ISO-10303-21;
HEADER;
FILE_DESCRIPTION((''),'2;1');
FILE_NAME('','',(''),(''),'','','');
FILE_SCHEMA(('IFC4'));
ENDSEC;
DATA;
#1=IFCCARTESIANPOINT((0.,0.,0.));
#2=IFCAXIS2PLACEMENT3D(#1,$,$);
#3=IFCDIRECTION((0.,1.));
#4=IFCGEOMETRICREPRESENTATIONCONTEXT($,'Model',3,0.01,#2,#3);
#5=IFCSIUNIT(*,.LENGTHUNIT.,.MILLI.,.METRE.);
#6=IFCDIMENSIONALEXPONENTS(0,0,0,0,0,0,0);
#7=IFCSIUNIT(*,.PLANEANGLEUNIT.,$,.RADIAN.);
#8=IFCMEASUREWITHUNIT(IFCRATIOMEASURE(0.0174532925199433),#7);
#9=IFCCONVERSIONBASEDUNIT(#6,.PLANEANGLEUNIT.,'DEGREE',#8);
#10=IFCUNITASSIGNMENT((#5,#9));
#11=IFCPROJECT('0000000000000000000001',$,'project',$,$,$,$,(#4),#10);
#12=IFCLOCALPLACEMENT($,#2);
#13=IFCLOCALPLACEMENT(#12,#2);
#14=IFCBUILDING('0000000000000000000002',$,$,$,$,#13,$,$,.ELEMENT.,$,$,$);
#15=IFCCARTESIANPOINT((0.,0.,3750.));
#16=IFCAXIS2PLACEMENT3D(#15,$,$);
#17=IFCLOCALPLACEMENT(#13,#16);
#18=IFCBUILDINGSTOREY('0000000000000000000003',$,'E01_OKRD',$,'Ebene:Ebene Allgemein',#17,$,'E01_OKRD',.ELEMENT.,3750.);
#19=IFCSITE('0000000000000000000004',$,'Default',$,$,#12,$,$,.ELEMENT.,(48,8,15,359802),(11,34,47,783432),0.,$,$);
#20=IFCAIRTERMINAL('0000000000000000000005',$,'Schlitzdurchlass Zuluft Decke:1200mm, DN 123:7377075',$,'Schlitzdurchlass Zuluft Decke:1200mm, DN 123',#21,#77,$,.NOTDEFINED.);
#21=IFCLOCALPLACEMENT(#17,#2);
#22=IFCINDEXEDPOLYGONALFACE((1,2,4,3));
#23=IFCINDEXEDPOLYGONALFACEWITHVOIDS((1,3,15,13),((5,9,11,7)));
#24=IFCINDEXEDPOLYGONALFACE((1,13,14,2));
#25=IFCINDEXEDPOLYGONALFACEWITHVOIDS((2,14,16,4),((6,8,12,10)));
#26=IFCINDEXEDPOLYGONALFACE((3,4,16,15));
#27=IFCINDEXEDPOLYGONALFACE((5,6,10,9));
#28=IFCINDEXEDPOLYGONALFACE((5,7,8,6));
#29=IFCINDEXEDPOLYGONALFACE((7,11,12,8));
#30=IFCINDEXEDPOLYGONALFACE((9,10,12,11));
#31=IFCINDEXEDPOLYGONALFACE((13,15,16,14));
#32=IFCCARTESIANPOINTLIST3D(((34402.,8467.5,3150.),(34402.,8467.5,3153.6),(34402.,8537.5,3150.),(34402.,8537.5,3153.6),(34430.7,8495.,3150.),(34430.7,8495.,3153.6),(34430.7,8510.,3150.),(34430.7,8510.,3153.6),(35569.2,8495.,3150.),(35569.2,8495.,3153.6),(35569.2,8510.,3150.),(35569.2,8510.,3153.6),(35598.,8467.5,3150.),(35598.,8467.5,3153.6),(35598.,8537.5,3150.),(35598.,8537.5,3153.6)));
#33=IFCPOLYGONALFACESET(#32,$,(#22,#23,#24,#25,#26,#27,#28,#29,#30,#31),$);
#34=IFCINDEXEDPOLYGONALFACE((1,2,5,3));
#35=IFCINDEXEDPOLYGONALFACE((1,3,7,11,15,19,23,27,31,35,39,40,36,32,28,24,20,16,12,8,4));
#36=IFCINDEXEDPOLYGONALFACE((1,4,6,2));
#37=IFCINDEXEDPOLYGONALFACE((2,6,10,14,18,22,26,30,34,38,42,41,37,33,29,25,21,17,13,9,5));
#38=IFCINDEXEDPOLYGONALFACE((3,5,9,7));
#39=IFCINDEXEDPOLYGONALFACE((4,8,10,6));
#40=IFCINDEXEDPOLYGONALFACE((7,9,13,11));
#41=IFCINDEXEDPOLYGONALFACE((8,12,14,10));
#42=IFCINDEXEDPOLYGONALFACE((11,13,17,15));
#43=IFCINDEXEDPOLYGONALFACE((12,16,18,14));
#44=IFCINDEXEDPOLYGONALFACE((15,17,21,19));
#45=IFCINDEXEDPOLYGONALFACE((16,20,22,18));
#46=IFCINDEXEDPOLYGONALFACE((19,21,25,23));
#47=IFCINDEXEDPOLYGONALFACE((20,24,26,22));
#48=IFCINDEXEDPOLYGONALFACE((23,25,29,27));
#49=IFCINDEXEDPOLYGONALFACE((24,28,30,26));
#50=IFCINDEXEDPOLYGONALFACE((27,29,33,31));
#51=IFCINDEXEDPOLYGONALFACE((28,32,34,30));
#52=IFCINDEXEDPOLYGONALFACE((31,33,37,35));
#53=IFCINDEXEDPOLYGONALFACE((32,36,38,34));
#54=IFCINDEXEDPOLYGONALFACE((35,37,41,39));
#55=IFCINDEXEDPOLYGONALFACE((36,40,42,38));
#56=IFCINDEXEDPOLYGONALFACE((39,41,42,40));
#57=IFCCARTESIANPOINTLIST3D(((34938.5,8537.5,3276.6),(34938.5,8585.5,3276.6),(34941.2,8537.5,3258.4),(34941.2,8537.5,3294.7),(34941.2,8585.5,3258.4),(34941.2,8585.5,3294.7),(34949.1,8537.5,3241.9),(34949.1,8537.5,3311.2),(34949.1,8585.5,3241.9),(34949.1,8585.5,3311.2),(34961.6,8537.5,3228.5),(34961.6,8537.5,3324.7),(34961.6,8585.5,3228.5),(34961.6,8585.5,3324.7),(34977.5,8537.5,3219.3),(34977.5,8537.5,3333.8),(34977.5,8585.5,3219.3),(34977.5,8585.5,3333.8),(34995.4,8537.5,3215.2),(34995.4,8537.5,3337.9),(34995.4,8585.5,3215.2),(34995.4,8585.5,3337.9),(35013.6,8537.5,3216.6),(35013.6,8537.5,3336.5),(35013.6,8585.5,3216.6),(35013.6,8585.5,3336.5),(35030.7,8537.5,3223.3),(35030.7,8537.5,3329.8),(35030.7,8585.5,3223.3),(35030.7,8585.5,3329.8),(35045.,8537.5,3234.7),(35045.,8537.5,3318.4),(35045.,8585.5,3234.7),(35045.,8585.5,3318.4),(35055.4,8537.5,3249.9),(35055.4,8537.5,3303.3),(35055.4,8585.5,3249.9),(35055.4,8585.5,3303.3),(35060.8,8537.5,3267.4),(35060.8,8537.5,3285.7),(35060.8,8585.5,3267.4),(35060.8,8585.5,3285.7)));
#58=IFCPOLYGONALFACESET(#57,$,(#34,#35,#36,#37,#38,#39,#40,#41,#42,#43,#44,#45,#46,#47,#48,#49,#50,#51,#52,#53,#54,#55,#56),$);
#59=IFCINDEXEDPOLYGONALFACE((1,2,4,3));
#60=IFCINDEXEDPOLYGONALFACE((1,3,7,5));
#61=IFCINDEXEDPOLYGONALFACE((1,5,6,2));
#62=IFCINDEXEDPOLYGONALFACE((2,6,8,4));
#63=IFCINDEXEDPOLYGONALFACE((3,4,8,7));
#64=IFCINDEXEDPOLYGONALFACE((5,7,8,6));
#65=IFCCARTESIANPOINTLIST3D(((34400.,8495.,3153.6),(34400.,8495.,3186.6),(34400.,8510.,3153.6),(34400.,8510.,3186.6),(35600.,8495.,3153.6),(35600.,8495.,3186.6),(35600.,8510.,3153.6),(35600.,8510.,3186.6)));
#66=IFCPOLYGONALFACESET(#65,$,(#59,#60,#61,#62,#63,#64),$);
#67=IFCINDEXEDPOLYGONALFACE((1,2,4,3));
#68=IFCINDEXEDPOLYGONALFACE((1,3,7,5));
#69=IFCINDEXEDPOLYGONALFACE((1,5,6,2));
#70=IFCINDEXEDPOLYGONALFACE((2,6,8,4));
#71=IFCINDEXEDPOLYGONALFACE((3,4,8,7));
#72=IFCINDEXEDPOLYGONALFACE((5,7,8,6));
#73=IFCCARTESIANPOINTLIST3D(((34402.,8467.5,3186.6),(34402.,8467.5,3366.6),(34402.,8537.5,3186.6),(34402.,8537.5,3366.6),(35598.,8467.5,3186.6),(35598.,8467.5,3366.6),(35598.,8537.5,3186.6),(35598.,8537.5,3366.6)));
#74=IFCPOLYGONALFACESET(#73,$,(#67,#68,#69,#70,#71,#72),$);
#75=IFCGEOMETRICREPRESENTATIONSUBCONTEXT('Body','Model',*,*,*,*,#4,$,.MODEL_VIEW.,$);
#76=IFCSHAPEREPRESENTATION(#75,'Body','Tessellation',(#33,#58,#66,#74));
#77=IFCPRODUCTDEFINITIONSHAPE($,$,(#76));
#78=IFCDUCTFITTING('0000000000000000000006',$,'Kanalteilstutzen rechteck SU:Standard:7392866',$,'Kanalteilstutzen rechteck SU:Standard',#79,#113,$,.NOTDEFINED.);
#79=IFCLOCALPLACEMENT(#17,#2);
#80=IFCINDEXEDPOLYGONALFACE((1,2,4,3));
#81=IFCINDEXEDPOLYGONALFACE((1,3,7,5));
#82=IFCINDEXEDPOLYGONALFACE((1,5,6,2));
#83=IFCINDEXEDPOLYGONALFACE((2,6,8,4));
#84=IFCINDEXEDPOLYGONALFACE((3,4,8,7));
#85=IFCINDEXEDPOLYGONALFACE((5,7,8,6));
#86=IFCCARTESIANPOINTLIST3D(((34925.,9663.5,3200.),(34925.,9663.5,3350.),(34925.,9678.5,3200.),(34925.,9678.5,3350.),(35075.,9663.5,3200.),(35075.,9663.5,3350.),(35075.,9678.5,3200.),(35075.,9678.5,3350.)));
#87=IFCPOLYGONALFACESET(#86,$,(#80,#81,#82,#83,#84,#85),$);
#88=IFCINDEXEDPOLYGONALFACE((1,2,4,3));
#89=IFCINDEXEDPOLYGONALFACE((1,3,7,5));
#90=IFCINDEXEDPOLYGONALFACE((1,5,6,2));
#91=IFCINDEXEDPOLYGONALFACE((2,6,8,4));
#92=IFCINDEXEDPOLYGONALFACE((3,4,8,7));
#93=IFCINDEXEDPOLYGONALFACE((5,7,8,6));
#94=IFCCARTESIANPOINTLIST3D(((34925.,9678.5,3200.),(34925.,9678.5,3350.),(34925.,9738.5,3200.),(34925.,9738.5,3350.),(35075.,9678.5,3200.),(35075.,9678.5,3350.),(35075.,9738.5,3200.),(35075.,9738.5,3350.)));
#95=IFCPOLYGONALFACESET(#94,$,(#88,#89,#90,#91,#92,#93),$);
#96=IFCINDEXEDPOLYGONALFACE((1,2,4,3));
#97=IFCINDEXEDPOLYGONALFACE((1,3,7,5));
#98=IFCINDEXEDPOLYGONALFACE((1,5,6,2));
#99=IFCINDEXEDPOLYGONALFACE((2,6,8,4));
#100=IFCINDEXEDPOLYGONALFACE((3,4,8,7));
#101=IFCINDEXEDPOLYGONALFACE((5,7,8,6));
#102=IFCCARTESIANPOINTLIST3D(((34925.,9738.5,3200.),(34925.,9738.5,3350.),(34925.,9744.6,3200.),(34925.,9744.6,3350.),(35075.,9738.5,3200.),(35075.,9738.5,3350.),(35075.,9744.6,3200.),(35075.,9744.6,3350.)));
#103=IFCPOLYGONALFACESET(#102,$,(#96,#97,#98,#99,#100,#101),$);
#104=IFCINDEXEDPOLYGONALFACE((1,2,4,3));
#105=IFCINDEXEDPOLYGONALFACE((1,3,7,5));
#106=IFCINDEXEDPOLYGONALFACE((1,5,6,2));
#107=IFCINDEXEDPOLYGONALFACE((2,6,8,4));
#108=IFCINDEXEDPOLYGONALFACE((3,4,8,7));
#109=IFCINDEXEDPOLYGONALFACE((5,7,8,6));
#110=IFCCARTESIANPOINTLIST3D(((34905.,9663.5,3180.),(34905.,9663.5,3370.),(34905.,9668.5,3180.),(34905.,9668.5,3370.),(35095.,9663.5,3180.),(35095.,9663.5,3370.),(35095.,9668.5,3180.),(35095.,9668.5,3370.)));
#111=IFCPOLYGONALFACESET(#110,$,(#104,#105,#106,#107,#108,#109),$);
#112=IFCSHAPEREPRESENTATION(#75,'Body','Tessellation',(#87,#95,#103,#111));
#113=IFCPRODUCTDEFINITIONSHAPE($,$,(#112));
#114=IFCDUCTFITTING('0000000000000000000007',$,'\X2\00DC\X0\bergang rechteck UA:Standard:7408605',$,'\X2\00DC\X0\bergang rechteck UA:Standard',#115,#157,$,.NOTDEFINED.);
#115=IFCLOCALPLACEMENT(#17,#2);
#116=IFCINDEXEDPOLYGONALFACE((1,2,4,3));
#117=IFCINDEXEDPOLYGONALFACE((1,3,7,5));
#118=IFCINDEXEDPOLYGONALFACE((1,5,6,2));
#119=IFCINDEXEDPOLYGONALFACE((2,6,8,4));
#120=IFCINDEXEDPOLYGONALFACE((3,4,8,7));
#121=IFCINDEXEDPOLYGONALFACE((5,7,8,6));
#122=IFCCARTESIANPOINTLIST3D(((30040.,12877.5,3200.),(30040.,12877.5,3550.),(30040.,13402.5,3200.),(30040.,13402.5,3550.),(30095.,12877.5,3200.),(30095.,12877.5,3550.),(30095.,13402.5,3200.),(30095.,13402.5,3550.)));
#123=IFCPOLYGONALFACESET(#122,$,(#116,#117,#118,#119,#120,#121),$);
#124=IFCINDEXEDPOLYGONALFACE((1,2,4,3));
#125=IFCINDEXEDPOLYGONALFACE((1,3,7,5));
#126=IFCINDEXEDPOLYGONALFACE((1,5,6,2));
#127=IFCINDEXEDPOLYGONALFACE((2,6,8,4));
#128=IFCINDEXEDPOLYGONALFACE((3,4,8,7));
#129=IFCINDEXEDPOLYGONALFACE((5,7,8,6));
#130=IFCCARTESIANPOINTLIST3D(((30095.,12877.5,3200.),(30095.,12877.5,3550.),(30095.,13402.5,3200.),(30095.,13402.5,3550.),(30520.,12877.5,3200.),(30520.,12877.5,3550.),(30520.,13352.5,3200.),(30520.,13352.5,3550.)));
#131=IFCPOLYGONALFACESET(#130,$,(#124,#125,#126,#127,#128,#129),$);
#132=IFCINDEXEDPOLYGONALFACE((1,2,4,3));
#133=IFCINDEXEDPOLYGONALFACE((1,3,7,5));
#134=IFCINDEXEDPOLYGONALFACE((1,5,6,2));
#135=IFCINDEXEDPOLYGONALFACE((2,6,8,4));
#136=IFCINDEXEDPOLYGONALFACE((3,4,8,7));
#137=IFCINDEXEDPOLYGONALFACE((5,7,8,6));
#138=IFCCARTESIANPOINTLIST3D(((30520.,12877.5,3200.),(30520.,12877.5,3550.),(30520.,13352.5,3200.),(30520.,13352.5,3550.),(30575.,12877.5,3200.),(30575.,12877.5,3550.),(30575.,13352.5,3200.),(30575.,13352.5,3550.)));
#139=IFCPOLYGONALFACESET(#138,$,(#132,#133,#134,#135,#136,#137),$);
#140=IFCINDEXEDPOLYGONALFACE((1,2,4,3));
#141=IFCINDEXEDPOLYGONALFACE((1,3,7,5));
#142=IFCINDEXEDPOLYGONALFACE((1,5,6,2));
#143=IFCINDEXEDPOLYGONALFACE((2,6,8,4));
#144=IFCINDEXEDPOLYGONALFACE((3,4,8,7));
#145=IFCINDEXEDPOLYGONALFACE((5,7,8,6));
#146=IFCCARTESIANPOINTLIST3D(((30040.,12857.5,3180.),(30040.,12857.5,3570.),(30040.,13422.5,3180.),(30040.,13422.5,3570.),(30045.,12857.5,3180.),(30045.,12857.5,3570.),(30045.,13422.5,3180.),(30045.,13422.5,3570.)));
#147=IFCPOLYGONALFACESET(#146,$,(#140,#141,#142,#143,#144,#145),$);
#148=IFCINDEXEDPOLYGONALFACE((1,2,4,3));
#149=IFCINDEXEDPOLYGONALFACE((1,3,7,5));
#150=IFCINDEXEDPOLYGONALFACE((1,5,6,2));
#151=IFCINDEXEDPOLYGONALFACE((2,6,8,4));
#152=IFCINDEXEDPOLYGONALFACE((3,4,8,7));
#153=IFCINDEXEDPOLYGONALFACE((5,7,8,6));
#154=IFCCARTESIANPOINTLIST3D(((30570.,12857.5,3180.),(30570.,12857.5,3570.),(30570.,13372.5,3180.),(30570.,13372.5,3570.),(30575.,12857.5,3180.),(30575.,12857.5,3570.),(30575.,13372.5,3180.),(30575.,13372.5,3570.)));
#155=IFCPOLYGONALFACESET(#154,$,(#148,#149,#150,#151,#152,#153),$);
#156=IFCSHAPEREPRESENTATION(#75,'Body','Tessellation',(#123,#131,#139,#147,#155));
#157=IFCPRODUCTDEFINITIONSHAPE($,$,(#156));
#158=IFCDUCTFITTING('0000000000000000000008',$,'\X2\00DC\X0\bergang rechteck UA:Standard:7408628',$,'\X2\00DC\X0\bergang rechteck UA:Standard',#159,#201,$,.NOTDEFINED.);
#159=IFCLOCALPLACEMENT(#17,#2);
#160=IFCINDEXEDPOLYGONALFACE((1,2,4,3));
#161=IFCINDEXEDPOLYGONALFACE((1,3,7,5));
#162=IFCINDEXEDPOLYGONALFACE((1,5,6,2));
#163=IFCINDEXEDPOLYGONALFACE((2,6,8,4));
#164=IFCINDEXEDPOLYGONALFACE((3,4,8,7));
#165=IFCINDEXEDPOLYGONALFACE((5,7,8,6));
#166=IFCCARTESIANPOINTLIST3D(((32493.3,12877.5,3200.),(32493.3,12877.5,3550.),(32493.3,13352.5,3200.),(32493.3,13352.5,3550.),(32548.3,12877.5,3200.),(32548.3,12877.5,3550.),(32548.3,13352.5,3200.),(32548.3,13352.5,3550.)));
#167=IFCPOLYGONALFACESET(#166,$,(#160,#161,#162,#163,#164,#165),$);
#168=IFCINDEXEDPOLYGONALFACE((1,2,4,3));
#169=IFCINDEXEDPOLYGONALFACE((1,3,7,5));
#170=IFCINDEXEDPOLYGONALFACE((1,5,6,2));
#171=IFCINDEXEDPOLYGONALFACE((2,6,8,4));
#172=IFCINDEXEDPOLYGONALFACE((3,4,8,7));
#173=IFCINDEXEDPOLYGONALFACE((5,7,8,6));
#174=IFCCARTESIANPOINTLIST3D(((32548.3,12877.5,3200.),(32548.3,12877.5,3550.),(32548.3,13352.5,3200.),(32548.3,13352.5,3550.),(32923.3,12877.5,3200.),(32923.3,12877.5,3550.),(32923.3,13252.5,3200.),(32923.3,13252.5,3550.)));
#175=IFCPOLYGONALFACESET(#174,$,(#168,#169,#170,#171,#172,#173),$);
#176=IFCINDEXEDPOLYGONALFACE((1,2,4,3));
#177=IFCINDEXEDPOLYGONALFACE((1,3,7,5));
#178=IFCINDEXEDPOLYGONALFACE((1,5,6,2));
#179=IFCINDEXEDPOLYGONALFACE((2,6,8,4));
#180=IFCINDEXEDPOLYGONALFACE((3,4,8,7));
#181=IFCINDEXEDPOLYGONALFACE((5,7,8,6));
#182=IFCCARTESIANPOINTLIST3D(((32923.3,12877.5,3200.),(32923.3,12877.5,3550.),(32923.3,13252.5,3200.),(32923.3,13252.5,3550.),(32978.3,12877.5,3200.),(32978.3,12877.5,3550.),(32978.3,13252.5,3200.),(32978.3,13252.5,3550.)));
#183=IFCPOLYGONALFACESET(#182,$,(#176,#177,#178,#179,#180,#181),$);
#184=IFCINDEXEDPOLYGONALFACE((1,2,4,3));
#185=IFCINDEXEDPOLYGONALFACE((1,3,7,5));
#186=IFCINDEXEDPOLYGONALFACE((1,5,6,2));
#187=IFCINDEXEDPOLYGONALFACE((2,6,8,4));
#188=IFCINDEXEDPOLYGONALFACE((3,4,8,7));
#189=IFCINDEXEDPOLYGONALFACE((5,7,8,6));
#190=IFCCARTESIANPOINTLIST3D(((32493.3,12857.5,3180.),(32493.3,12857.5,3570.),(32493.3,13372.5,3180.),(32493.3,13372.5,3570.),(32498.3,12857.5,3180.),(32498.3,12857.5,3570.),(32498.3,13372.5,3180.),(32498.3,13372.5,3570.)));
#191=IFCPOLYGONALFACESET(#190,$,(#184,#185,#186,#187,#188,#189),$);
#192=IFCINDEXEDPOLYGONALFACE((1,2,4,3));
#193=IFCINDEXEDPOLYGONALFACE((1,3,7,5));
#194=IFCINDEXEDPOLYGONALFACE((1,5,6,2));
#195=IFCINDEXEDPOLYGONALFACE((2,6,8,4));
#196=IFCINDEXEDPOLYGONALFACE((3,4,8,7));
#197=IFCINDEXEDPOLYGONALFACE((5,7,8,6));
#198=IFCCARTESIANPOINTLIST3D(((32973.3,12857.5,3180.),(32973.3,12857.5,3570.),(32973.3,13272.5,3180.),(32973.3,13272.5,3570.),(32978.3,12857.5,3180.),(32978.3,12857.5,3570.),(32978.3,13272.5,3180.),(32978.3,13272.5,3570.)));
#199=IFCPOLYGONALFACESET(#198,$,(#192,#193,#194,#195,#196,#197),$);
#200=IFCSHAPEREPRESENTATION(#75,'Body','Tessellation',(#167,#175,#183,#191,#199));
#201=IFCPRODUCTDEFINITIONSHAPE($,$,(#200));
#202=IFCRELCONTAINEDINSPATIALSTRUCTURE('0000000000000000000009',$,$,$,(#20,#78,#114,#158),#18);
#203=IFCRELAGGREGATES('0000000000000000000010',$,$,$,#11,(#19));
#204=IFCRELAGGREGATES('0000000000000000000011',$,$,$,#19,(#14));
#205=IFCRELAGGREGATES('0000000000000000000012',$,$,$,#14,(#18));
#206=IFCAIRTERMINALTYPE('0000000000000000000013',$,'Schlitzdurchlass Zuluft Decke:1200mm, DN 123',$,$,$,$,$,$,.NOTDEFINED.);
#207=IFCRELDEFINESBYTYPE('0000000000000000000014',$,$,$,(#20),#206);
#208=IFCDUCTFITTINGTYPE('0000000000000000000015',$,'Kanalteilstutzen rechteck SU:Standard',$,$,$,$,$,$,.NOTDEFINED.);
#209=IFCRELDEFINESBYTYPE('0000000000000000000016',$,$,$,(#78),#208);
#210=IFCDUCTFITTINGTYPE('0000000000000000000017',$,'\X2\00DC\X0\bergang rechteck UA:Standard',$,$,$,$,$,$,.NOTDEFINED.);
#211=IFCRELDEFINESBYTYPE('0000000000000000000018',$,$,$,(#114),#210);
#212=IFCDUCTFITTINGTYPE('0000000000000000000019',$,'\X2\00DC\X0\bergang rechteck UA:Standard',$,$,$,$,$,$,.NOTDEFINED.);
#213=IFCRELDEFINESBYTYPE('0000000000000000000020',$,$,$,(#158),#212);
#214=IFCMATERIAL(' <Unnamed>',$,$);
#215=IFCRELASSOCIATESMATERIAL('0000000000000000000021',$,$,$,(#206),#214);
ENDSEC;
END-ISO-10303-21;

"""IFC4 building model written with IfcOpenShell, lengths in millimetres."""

from ifc_helpers import new_model, entity, si_unit, converted_unit, direction, frame, frame_2d, origin, origin_2d_with_axis, place, context, subcontext, project, spatial, polyline, rectangle, circle, outline, extrude, source, transform, mapped, material, type_object, type_shapes, element, save


model = new_model("IFC4")

# Units and contexts
model_context = context("Model", 3, precision=0.01, world=origin(), true_north=direction((0.0, 1.0)))
body_context = subcontext(model_context, "Body", "Model", "MODEL_VIEW")
ifc_project = project(units=[si_unit("LENGTHUNIT", "METRE", prefix="MILLI"), converted_unit("PLANEANGLEUNIT", "DEGREE", entity("IfcRatioMeasure", 0.0174532925199433), si_unit("PLANEANGLEUNIT", "RADIAN"), dimensions=[0, 0, 0, 0, 0, 0, 0])], contexts=[model_context])

# Site, building, storey
site_placement = place(None, origin())
site = spatial("IfcSite", under=ifc_project, at=site_placement, Name="Default", CompositionType="ELEMENT", RefLatitude=(48, 8, 15, 359802), RefLongitude=(11, 34, 47, 783432), RefElevation=0.0)
building_placement = place(site_placement, origin())
building = spatial("IfcBuilding", under=site, at=building_placement, CompositionType="ELEMENT")
storey_placement = place(building_placement, frame((0.0, 0.0, 3750.0)))
storey = spatial("IfcBuildingStorey", under=building, at=storey_placement, Name="E01_OKRD", ObjectType="Ebene:Ebene Allgemein", LongName="E01_OKRD", CompositionType="ELEMENT", Elevation=3750.0)

# Air terminal
ifc_material_1 = material(Name=" <Unnamed>")
air_terminal_type_1 = type_object("IfcAirTerminalType", Name="Schlitzdurchlass Zuluft Decke:1200mm, DN 123", PredefinedType="NOTDEFINED", material=ifc_material_1)
shared_shape_1 = source(origin(), body_context, "Body", "SweptSolid", [
    extrude(outline(polyline([(-598.0, -35.0), (598.0, -35.0), (598.0, 35.0), (-598.0, 35.0), (-598.0, -35.0)]), holes=[polyline([(-569.2, -7.5), (-569.2, 7.5), (569.2, 7.5), (569.2, -7.5), (-569.2, -7.5)])]), frame((600.0, 35.0, 0.0), z_axis=(0.0, 0.0, 1.0), x_axis=(-1.0, 0.0, 0.0)), (0.0, 0.0, 1.0), 3.6),
    extrude(circle(Radius=61.5, at=frame_2d((0.0, 0.0), x_axis=(1.0, 0.0))), frame((600.0, 70.0, 126.6), z_axis=(0.0, 1.0, 0.0), x_axis=(-1.0, 0.0, 0.0)), (0.0, 0.0, 1.0), 48.0),
    extrude(rectangle(XDim=1200.0, YDim=15.0, at=origin_2d_with_axis()), frame((600.0, 35.0, 3.6), z_axis=(0.0, 0.0, 1.0), x_axis=(-1.0, 0.0, 0.0)), (0.0, 0.0, 1.0), 33.0),
    extrude(rectangle(XDim=1196.0, YDim=70.0, at=origin_2d_with_axis()), frame((600.0, 35.0, 36.6), z_axis=(0.0, 0.0, 1.0), x_axis=(-1.0, 0.0, 0.0)), (0.0, 0.0, 1.0), 180.0),
])
type_shapes(air_terminal_type_1, [shared_shape_1])
air_terminal_1_placement = place(storey_placement, frame((34400.0, 8467.5, 3150.0)))
element("IfcAirTerminal", 1, at=air_terminal_1_placement, inside=storey, type_object=air_terminal_type_1, Name="Schlitzdurchlass Zuluft Decke:1200mm, DN 123:7377075", ObjectType="Schlitzdurchlass Zuluft Decke:1200mm, DN 123", PredefinedType="NOTDEFINED", context=body_context, shape_type="MappedRepresentation", body=[
    mapped(shared_shape_1, transform((0.0, 0.0, 0.0), scale=1.0)),
])

# Duct fittings
duct_fitting_type_1 = type_object("IfcDuctFittingType", Name="Kanalteilstutzen rechteck SU:Standard", PredefinedType="NOTDEFINED")
shared_shape_2 = source(origin(), body_context, "Body", "SweptSolid", [
    extrude(rectangle(XDim=150.0, YDim=15.0, at=origin_2d_with_axis()), frame((67.5, 0.0, -75.0), z_axis=(0.0, 0.0, 1.0), x_axis=(0.0, -1.0, 0.0)), (0.0, 0.0, 1.0), 150.0),
    extrude(rectangle(XDim=150.0, YDim=60.0, at=frame_2d((0.0, 0.0), x_axis=(1.0, 0.0))), frame((30.0, 0.0, -75.0), z_axis=(0.0, 0.0, 1.0), x_axis=(0.0, -1.0, 0.0)), (0.0, 0.0, 1.0), 150.0),
    extrude(rectangle(XDim=150.0, YDim=6.1, at=frame_2d((0.0, 0.0), x_axis=(1.0, 0.0))), frame((-3.0, 0.0, -75.0), z_axis=(0.0, 0.0, 1.0), x_axis=(0.0, -1.0, 0.0)), (0.0, 0.0, 1.0), 150.0),
    extrude(rectangle(XDim=190.0, YDim=5.0, at=origin_2d_with_axis()), frame((72.5, 0.0, -95.0), z_axis=(0.0, 0.0, 1.0), x_axis=(0.0, -1.0, 0.0)), (0.0, 0.0, 1.0), 190.0),
])
type_shapes(duct_fitting_type_1, [shared_shape_2])
duct_fitting_1_placement = place(storey_placement, frame((35000.0, 9738.5, 3275.0), z_axis=(0.0, -0.000027, -1.0), x_axis=(0.0, -1.0, 0.000027)))
element("IfcDuctFitting", 2, at=duct_fitting_1_placement, inside=storey, type_object=duct_fitting_type_1, Name="Kanalteilstutzen rechteck SU:Standard:7392866", ObjectType="Kanalteilstutzen rechteck SU:Standard", PredefinedType="NOTDEFINED", context=body_context, shape_type="MappedRepresentation", body=[
    mapped(shared_shape_2, transform((0.0, 0.0, 0.0), scale=1.0)),
])
duct_fitting_type_2 = type_object("IfcDuctFittingType", Name="Übergang rechteck UA:Standard", PredefinedType="NOTDEFINED")
shared_shape_3 = source(origin(), body_context, "Body", "SweptSolid", [
    extrude(rectangle(XDim=55.0, YDim=525.0, at=frame_2d((0.0, 0.0), x_axis=(1.0, 0.0))), frame((507.5, -25.0, -175.0)), (0.0, 0.0, 1.0), 350.0),
    extrude(outline(polyline([(-184.8, -248.3), (243.2, -248.3), (181.8, 273.1), (-240.3, 223.5), (-184.8, -248.3)])), frame((267.5, -12.5, -175.0), z_axis=(0.0, 0.0, 1.0), x_axis=(0.993151, -0.116841, 0.0)), (0.0, 0.0, 1.0), 350.0),
    extrude(rectangle(XDim=55.0, YDim=475.0, at=frame_2d((0.0, 0.0), x_axis=(1.0, 0.0))), frame((27.5, 0.0, -175.0)), (0.0, 0.0, 1.0), 350.0),
    extrude(rectangle(XDim=5.0, YDim=565.0, at=frame_2d((0.0, 0.0), x_axis=(1.0, 0.0))), frame((532.5, -25.0, -195.0)), (0.0, 0.0, 1.0), 390.0),
    extrude(rectangle(XDim=5.0, YDim=515.0, at=frame_2d((0.0, 0.0), x_axis=(1.0, 0.0))), frame((2.5, 0.0, -195.0)), (0.0, 0.0, 1.0), 390.0),
])
type_shapes(duct_fitting_type_2, [shared_shape_3])
duct_fitting_2_placement = place(storey_placement, frame((30575.0, 13115.0, 3375.0), z_axis=(0.0, 0.0, 1.0), x_axis=(-1.0, 0.0, 0.0)))
element("IfcDuctFitting", 3, at=duct_fitting_2_placement, inside=storey, type_object=duct_fitting_type_2, Name="Übergang rechteck UA:Standard:7408605", ObjectType="Übergang rechteck UA:Standard", PredefinedType="NOTDEFINED", context=body_context, shape_type="MappedRepresentation", body=[
    mapped(shared_shape_3, transform((0.0, 0.0, 0.0), scale=1.0)),
])
duct_fitting_type_3 = type_object("IfcDuctFittingType", Name="Übergang rechteck UA:Standard", PredefinedType="NOTDEFINED")
shared_shape_4 = source(origin(), body_context, "Body", "SweptSolid", [
    extrude(rectangle(XDim=55.0, YDim=475.0, at=frame_2d((0.0, 0.0), x_axis=(1.0, 0.0))), frame((457.5, -50.0, -175.0)), (0.0, 0.0, 1.0), 350.0),
    extrude(outline(polyline([(-139.3, -205.3), (248.8, -205.3), (126.4, 253.6), (-235.9, 157.0), (-139.3, -205.3)])), frame((242.5, -25.0, -175.0), z_axis=(0.0, 0.0, 1.0), x_axis=(0.966235, -0.257663, 0.0)), (0.0, 0.0, 1.0), 350.0),
    extrude(rectangle(XDim=55.0, YDim=375.0, at=frame_2d((0.0, 0.0), x_axis=(1.0, 0.0))), frame((27.5, 0.0, -175.0)), (0.0, 0.0, 1.0), 350.0),
    extrude(rectangle(XDim=5.0, YDim=515.0, at=origin_2d_with_axis()), frame((482.5, -50.0, -195.0)), (0.0, 0.0, 1.0), 390.0),
    extrude(rectangle(XDim=5.0, YDim=415.0, at=frame_2d((0.0, 0.0), x_axis=(1.0, 0.0))), frame((2.5, 0.0, -195.0)), (0.0, 0.0, 1.0), 390.0),
])
type_shapes(duct_fitting_type_3, [shared_shape_4])
duct_fitting_3_placement = place(storey_placement, frame((32978.3, 13065.0, 3375.0), z_axis=(0.0, 0.0, 1.0), x_axis=(-1.0, 0.0, 0.0)))
element("IfcDuctFitting", 4, at=duct_fitting_3_placement, inside=storey, type_object=duct_fitting_type_3, Name="Übergang rechteck UA:Standard:7408628", ObjectType="Übergang rechteck UA:Standard", PredefinedType="NOTDEFINED", context=body_context, shape_type="MappedRepresentation", body=[
    mapped(shared_shape_4, transform((0.0, 0.0, 0.0), scale=1.0)),
])

save(model, "model.ifc")
